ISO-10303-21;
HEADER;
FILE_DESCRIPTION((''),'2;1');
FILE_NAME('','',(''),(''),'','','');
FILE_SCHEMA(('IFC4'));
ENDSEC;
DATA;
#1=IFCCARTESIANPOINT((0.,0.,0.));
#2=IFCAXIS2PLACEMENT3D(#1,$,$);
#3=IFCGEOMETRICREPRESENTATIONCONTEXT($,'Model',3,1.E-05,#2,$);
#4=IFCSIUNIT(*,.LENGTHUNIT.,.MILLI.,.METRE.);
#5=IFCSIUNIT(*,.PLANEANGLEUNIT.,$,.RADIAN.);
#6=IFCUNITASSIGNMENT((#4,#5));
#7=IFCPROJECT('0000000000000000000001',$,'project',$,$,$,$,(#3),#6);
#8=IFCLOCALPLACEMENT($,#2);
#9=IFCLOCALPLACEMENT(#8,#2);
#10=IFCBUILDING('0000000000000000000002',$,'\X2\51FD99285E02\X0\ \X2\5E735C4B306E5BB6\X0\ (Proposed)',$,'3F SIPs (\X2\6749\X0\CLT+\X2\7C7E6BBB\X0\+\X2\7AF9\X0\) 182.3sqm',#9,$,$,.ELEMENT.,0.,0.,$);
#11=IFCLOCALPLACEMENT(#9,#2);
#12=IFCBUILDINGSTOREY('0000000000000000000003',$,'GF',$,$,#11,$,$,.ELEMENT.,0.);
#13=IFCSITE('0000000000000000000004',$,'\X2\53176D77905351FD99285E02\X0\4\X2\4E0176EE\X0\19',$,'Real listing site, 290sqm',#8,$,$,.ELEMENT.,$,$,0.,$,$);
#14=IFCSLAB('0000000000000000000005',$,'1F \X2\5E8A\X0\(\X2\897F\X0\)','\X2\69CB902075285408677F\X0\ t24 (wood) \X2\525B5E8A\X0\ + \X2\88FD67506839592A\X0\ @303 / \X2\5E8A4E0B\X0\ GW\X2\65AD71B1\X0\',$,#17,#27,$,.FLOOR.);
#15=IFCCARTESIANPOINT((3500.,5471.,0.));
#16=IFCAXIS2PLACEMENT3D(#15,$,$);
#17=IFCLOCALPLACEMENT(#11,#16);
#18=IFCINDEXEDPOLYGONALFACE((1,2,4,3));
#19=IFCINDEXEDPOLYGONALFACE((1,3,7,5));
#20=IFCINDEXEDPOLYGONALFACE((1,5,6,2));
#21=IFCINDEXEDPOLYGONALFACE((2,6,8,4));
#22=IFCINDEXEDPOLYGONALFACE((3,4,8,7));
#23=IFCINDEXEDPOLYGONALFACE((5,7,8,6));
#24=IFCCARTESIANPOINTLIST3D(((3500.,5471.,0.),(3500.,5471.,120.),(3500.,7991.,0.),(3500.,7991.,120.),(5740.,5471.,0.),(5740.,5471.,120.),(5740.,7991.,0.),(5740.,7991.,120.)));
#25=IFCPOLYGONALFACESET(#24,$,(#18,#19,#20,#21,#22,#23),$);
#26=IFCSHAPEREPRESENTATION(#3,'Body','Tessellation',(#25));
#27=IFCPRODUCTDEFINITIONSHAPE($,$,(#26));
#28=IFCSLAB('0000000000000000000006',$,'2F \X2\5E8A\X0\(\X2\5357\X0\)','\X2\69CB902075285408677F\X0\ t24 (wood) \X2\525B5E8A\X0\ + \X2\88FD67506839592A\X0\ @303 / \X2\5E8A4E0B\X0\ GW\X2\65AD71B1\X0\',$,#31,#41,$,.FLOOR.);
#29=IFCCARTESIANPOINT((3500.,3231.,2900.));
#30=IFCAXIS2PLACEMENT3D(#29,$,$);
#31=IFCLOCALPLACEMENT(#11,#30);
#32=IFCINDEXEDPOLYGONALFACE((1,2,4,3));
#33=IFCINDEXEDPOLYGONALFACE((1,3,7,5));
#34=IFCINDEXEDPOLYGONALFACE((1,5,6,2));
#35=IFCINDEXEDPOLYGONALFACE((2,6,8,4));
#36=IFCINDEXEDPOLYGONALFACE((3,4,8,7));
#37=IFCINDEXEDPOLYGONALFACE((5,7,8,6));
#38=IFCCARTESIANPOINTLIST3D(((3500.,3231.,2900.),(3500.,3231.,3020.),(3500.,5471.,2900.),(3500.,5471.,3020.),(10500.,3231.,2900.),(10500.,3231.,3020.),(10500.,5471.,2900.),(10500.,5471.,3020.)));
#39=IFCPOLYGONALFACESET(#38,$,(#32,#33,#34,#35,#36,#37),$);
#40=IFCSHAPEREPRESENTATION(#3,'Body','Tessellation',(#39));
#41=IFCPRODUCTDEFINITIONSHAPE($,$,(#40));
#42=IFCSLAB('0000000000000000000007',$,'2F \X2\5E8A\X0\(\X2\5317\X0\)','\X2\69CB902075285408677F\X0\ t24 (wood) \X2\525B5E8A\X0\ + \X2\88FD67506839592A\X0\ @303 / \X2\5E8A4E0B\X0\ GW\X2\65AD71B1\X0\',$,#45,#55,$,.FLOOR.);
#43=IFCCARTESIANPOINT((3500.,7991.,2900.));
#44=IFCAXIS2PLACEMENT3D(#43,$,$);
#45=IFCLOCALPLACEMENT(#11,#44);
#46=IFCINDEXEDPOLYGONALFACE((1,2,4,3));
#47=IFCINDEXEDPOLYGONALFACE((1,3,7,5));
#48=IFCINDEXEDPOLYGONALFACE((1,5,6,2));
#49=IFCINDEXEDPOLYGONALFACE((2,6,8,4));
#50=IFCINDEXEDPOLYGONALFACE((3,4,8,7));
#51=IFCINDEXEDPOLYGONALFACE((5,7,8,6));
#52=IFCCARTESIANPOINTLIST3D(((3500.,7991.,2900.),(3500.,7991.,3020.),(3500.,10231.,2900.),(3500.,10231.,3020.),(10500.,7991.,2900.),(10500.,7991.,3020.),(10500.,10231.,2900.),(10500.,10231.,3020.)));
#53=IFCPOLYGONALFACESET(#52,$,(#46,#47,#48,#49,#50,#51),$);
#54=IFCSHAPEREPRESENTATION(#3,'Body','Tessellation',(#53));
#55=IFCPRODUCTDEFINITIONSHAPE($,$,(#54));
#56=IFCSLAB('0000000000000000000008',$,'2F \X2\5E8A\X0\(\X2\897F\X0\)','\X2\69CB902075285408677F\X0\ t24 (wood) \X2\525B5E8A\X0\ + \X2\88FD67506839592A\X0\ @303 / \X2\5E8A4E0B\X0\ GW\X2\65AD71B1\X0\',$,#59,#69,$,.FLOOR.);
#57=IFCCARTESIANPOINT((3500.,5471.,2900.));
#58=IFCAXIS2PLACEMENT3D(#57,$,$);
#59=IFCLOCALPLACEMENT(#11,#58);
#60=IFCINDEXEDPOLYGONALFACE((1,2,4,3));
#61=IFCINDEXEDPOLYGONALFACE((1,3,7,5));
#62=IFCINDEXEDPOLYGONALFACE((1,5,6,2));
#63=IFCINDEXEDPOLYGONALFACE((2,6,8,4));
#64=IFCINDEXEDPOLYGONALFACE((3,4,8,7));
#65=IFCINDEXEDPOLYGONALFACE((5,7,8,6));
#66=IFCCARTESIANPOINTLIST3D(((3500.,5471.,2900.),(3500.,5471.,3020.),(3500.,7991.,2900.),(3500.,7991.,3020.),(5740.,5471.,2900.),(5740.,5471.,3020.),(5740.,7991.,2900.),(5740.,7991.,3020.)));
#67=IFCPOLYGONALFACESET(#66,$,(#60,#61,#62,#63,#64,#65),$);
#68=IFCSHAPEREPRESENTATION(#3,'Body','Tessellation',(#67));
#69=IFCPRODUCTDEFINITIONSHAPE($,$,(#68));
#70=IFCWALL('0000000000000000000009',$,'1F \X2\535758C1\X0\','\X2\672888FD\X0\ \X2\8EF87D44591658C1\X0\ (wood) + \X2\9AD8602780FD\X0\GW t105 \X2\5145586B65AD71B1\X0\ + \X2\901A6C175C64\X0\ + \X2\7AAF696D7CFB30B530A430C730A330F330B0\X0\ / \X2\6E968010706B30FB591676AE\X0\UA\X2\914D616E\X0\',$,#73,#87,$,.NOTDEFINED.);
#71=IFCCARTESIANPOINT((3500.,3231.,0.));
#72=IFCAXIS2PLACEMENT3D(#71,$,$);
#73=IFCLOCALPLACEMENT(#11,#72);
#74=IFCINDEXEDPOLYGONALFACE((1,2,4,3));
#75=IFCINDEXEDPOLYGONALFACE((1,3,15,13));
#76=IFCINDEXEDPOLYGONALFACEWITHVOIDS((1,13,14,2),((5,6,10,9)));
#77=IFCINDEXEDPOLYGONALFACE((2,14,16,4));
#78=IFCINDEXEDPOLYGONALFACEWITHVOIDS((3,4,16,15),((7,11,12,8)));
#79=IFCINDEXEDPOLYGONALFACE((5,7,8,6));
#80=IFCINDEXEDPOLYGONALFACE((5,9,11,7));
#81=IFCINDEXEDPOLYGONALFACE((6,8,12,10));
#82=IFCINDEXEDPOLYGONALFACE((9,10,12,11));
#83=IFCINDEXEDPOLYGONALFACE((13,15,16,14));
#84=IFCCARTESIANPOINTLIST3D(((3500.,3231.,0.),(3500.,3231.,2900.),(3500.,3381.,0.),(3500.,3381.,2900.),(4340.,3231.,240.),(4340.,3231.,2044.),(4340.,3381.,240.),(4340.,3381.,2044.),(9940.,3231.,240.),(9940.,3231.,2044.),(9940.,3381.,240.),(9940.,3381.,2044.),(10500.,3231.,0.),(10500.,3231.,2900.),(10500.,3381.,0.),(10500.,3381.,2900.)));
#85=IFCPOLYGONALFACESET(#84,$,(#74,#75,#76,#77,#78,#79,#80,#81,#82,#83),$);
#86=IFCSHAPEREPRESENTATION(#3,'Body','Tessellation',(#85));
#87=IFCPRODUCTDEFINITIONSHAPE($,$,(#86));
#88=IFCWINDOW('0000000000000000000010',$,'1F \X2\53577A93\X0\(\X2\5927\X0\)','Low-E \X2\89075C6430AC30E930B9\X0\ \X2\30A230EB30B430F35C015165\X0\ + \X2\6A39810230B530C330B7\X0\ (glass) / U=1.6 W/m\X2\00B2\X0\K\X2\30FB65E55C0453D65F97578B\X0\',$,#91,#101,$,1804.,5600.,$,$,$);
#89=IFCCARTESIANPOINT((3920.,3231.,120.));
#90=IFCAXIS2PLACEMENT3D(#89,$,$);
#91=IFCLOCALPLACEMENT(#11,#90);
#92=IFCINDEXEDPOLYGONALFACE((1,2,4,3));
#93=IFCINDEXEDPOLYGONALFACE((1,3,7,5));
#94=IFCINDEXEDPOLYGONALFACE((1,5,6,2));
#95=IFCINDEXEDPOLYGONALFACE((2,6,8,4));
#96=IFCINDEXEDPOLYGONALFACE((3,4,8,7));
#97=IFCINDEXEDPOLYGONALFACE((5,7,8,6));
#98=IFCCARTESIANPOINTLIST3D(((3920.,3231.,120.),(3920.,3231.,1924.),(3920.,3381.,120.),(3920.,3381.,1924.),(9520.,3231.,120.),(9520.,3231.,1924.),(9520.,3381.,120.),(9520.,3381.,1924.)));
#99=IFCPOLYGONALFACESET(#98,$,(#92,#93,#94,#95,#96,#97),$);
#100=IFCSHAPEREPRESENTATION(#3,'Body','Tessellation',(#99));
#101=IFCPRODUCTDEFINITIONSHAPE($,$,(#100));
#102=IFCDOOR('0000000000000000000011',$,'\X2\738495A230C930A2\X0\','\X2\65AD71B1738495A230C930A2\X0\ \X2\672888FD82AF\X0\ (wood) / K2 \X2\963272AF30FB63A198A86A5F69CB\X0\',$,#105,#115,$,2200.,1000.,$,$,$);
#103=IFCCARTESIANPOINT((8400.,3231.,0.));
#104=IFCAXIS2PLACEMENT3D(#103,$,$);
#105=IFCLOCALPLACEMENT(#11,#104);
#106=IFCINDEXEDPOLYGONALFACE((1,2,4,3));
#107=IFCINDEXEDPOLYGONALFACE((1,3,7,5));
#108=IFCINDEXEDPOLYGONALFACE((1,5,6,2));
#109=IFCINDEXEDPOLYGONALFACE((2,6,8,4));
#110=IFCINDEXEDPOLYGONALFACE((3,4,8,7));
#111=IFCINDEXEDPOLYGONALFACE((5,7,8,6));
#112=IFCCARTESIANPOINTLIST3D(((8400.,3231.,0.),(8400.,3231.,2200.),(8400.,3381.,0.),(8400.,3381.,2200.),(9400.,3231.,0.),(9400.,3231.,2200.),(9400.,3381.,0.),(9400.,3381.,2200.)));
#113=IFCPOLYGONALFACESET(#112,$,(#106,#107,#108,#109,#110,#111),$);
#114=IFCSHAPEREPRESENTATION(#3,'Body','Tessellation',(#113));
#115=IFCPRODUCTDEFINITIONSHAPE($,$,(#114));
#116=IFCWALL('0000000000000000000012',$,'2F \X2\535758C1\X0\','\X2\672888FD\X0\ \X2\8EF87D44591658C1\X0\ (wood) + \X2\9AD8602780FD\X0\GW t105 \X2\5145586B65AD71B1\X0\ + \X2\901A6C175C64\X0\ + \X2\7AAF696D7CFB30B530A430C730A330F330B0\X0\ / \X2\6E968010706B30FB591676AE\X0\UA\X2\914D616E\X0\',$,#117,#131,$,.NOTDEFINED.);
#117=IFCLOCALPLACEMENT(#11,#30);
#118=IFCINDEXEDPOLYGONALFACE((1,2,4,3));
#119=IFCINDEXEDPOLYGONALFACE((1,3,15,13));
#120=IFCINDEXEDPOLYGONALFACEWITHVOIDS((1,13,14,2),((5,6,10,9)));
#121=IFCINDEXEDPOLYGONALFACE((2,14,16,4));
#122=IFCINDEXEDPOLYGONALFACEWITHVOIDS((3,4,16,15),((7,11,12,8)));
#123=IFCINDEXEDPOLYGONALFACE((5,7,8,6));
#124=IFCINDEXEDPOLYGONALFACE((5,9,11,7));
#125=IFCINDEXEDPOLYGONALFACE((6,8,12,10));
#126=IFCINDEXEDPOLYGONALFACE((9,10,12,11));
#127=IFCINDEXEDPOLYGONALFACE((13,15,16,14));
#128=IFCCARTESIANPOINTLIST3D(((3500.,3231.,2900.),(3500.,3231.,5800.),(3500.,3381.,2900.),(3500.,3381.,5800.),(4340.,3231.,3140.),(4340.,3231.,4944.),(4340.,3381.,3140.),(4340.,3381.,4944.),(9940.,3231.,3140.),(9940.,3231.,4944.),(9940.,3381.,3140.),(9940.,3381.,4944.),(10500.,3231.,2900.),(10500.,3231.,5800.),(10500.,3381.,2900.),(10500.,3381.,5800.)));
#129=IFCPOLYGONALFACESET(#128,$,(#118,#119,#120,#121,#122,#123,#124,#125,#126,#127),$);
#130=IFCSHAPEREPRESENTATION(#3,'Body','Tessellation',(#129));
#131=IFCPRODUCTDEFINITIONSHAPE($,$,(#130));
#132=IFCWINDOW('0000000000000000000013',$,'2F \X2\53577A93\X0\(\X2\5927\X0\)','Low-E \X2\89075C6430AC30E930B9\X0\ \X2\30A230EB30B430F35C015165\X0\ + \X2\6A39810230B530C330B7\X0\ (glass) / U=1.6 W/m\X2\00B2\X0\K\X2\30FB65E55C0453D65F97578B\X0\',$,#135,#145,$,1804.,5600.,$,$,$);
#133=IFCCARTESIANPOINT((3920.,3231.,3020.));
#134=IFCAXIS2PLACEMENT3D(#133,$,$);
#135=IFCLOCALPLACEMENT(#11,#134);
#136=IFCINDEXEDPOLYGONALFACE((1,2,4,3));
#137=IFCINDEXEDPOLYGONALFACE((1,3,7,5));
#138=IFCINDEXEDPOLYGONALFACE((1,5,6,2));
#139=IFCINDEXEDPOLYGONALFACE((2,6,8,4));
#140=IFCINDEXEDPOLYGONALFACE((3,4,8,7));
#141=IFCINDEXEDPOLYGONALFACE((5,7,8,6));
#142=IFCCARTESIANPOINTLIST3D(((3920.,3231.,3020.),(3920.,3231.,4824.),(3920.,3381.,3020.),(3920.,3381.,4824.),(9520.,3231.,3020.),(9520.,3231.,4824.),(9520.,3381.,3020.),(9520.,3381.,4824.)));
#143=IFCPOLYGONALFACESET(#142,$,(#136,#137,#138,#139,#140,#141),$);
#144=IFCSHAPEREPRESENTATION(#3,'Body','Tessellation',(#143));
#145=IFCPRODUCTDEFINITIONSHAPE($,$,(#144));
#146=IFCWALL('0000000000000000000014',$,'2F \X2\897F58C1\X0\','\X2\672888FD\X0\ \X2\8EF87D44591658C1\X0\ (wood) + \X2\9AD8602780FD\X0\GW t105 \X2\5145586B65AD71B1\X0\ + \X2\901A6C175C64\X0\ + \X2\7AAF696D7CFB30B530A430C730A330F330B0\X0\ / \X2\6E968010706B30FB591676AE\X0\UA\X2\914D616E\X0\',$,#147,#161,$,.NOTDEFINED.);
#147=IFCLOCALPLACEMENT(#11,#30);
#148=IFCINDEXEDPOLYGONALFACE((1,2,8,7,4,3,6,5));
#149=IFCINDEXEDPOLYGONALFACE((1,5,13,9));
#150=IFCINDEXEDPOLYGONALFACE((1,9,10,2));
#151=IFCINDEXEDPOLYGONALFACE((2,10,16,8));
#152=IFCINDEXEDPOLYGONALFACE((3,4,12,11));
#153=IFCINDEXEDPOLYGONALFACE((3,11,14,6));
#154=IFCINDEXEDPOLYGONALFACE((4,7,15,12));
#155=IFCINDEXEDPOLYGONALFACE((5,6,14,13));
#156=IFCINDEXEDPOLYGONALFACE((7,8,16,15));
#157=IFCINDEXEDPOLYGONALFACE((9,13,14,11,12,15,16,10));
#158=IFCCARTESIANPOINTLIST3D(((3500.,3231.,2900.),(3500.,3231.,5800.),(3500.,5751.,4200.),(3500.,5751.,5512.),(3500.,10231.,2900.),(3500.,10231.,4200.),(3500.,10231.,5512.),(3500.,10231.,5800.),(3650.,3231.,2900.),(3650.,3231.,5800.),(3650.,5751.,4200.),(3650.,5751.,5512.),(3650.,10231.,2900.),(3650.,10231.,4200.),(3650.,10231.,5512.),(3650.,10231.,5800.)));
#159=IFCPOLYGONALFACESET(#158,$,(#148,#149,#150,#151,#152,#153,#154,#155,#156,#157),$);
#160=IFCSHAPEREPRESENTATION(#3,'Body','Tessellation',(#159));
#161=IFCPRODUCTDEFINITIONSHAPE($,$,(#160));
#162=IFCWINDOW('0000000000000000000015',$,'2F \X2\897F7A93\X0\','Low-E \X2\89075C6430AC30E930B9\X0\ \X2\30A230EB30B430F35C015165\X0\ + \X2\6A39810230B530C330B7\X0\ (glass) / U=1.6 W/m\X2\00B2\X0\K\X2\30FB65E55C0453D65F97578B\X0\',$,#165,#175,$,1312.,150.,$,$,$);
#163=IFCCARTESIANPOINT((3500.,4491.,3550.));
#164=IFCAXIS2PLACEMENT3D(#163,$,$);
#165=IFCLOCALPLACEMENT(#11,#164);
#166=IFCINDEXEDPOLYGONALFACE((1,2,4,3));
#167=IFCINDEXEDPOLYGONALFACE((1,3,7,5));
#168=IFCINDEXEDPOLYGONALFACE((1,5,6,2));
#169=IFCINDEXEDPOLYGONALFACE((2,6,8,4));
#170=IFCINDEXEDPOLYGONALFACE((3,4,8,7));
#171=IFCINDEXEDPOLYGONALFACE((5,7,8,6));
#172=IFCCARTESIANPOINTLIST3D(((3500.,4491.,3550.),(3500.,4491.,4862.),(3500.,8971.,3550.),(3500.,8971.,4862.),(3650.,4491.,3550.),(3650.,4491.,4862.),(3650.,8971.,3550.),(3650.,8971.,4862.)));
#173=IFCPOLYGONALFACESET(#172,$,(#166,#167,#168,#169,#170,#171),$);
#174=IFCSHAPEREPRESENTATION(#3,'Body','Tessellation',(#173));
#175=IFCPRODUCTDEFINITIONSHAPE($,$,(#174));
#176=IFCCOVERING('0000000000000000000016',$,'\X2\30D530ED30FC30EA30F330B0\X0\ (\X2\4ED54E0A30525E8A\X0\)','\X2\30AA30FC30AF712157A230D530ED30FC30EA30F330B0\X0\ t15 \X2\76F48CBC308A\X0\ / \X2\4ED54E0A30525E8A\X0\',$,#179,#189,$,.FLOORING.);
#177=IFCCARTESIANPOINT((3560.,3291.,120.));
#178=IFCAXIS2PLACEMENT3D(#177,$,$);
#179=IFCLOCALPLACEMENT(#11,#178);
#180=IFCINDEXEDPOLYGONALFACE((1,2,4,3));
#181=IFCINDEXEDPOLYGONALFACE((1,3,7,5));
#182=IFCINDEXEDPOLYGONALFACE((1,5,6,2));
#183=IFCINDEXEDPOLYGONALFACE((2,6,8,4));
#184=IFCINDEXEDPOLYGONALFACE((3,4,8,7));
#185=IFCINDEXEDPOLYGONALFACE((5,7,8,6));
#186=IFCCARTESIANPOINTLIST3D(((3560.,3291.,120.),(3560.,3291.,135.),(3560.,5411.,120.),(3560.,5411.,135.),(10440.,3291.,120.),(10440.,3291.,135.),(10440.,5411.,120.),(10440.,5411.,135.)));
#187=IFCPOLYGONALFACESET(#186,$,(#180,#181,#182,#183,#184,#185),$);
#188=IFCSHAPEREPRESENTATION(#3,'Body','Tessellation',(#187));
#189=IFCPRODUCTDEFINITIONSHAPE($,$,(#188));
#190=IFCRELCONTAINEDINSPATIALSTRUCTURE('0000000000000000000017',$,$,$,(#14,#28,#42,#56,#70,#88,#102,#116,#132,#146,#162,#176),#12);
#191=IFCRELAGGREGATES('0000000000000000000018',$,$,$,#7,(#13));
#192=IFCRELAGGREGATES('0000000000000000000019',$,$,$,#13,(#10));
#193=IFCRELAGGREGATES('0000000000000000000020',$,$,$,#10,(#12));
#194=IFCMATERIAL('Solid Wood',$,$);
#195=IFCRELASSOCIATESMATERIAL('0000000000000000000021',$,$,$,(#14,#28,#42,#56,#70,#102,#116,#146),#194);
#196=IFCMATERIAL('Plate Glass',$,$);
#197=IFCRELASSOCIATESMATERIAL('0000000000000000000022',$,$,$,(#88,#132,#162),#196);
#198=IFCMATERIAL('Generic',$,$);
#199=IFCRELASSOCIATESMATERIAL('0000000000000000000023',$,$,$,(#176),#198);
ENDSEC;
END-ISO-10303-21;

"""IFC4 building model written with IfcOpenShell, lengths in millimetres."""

from ifc_helpers import new_model, si_unit, frame, frame_2d, origin, place, context, project, spatial, rectangle, extrude, material, element, fill, save


model = new_model("IFC4")

# Units and contexts
model_context = context("Model", 3, precision=1e-05, world=origin())
ifc_project = project(units=[si_unit("LENGTHUNIT", "METRE", prefix="MILLI"), si_unit("PLANEANGLEUNIT", "RADIAN")], contexts=[model_context])

# Site, building, storey
site_placement = place(None, origin())
site = spatial("IfcSite", under=ifc_project, at=site_placement, Name="北海道函館市4丁目19", ObjectType="Real listing site, 290sqm", CompositionType="ELEMENT", RefElevation=0.0)
building_placement = place(site_placement, origin())
building = spatial("IfcBuilding", under=site, at=building_placement, Name="函館市 平屋の家 (Proposed)", ObjectType="3F SIPs (杉CLT+籾殻+竹) 182.3sqm", CompositionType="ELEMENT", ElevationOfRefHeight=0.0, ElevationOfTerrain=0.0)
storey_placement = place(building_placement, origin())
storey = spatial("IfcBuildingStorey", under=building, at=storey_placement, Name="GF", CompositionType="ELEMENT", Elevation=0.0)

# Slabs
ifc_material_1 = material(Name="Solid Wood")
slab_1_placement = place(storey_placement, frame((3500.0, 5471.0, 0.0)))
element("IfcSlab", 1, at=slab_1_placement, inside=storey, material=ifc_material_1, Name="1F 床(西)", Description="構造用合板 t24 (wood) 剛床 + 製材根太 @303 / 床下 GW断熱", PredefinedType="FLOOR", context=model_context, shape_type="SweptSolid", body=[
    extrude(rectangle(XDim=2240.0, YDim=2520.0, at=frame_2d((1120.0, 1260.0))), frame((3500.0, 5471.0, 0.0)), (0.0, 0.0, 1.0), 120.0),
])
slab_2_placement = place(storey_placement, frame((3500.0, 3231.0, 2900.0)))
element("IfcSlab", 2, at=slab_2_placement, inside=storey, material=ifc_material_1, Name="2F 床(南)", Description="構造用合板 t24 (wood) 剛床 + 製材根太 @303 / 床下 GW断熱", PredefinedType="FLOOR", context=model_context, shape_type="SweptSolid", body=[
    extrude(rectangle(XDim=7000.0, YDim=2240.0, at=frame_2d((3500.0, 1120.0))), frame((3500.0, 3231.0, 2900.0)), (0.0, 0.0, 1.0), 120.0),
])
slab_3_placement = place(storey_placement, frame((3500.0, 7991.0, 2900.0)))
element("IfcSlab", 3, at=slab_3_placement, inside=storey, material=ifc_material_1, Name="2F 床(北)", Description="構造用合板 t24 (wood) 剛床 + 製材根太 @303 / 床下 GW断熱", PredefinedType="FLOOR", context=model_context, shape_type="SweptSolid", body=[
    extrude(rectangle(XDim=7000.0, YDim=2240.0, at=frame_2d((3500.0, 1120.0))), frame((3500.0, 7991.0, 2900.0)), (0.0, 0.0, 1.0), 120.0),
])
slab_4_placement = place(storey_placement, frame((3500.0, 5471.0, 2900.0)))
element("IfcSlab", 4, at=slab_4_placement, inside=storey, material=ifc_material_1, Name="2F 床(西)", Description="構造用合板 t24 (wood) 剛床 + 製材根太 @303 / 床下 GW断熱", PredefinedType="FLOOR", context=model_context, shape_type="SweptSolid", body=[
    extrude(rectangle(XDim=2240.0, YDim=2520.0, at=frame_2d((1120.0, 1260.0))), frame((3500.0, 5471.0, 2900.0)), (0.0, 0.0, 1.0), 120.0),
])

# Wall, openings, window, door
wall_1_placement = place(storey_placement, frame((3500.0, 3231.0, 0.0)))
wall_1 = element("IfcWall", 5, at=wall_1_placement, inside=storey, material=ifc_material_1, Name="1F 南壁", Description="木製 軸組外壁 (wood) + 高性能GW t105 充填断熱 + 通気層 + 窯業系サイディング / 準耐火・外皮UA配慮", PredefinedType="NOTDEFINED", context=model_context, shape_type="SweptSolid", body=[
    extrude(rectangle(XDim=7000.0, YDim=150.0, at=frame_2d((3500.0, 75.0))), frame((3500.0, 3231.0, 0.0)), (0.0, 0.0, 1.0), 2900.0),
])
opening_1_placement = place(storey_placement, frame((3920.0, 3231.0, 120.0)))
opening_1 = element("IfcOpeningElement", 6, at=opening_1_placement, cuts=wall_1, PredefinedType="NOTDEFINED", context=model_context, shape_type="SweptSolid", body=[
    extrude(rectangle(XDim=5600.0, YDim=150.0, at=frame_2d((2800.0, 75.0))), frame((3920.0, 3231.0, 120.0)), (0.0, 0.0, 1.0), 1804.0),
])
opening_2_placement = place(storey_placement, frame((8400.0, 3231.0, 0.0)))
opening_2 = element("IfcOpeningElement", 7, at=opening_2_placement, cuts=wall_1, PredefinedType="NOTDEFINED", context=model_context, shape_type="SweptSolid", body=[
    extrude(rectangle(XDim=1000.0, YDim=150.0, at=frame_2d((500.0, 75.0))), frame((8400.0, 3231.0, 0.0)), (0.0, 0.0, 1.0), 2200.0),
])
ifc_material_2 = material(Name="Plate Glass")
window_1_placement = place(storey_placement, frame((3920.0, 3231.0, 120.0)))
window_1 = element("IfcWindow", 8, at=window_1_placement, inside=storey, material=ifc_material_2, Name="1F 南窓(大)", Description="Low-E 複層ガラス アルゴン封入 + 樹脂サッシ (glass) / U=1.6 W/m²K・日射取得型", OverallHeight=1804.0, OverallWidth=5600.0, context=model_context, shape_type="SweptSolid", body=[
    extrude(rectangle(XDim=5600.0, YDim=150.0, at=frame_2d((2800.0, 75.0))), frame((3920.0, 3231.0, 120.0)), (0.0, 0.0, 1.0), 1804.0),
])
fill(opening_1, window_1)
door_placement = place(storey_placement, frame((8400.0, 3231.0, 0.0)))
door = element("IfcDoor", 9, at=door_placement, inside=storey, material=ifc_material_1, Name="玄関ドア", Description="断熱玄関ドア 木製芯 (wood) / K2 防犯・採風機構", OverallHeight=2200.0, OverallWidth=1000.0, context=model_context, shape_type="SweptSolid", body=[
    extrude(rectangle(XDim=1000.0, YDim=150.0, at=frame_2d((500.0, 75.0))), frame((8400.0, 3231.0, 0.0)), (0.0, 0.0, 1.0), 2200.0),
])
fill(opening_2, door)

# Wall, opening, window
wall_2_placement = place(storey_placement, frame((3500.0, 3231.0, 2900.0)))
wall_2 = element("IfcWall", 10, at=wall_2_placement, inside=storey, material=ifc_material_1, Name="2F 南壁", Description="木製 軸組外壁 (wood) + 高性能GW t105 充填断熱 + 通気層 + 窯業系サイディング / 準耐火・外皮UA配慮", PredefinedType="NOTDEFINED", context=model_context, shape_type="SweptSolid", body=[
    extrude(rectangle(XDim=7000.0, YDim=150.0, at=frame_2d((3500.0, 75.0))), frame((3500.0, 3231.0, 2900.0)), (0.0, 0.0, 1.0), 2900.0),
])
opening_3_placement = place(storey_placement, frame((3920.0, 3231.0, 3020.0)))
opening_3 = element("IfcOpeningElement", 11, at=opening_3_placement, cuts=wall_2, PredefinedType="NOTDEFINED", context=model_context, shape_type="SweptSolid", body=[
    extrude(rectangle(XDim=5600.0, YDim=150.0, at=frame_2d((2800.0, 75.0))), frame((3920.0, 3231.0, 3020.0)), (0.0, 0.0, 1.0), 1804.0),
])
window_2_placement = place(storey_placement, frame((3920.0, 3231.0, 3020.0)))
window_2 = element("IfcWindow", 12, at=window_2_placement, inside=storey, material=ifc_material_2, Name="2F 南窓(大)", Description="Low-E 複層ガラス アルゴン封入 + 樹脂サッシ (glass) / U=1.6 W/m²K・日射取得型", OverallHeight=1804.0, OverallWidth=5600.0, context=model_context, shape_type="SweptSolid", body=[
    extrude(rectangle(XDim=5600.0, YDim=150.0, at=frame_2d((2800.0, 75.0))), frame((3920.0, 3231.0, 3020.0)), (0.0, 0.0, 1.0), 1804.0),
])
fill(opening_3, window_2)

# Wall, opening, window
wall_3_placement = place(storey_placement, frame((3500.0, 3231.0, 2900.0)))
wall_3 = element("IfcWall", 13, at=wall_3_placement, inside=storey, material=ifc_material_1, Name="2F 西壁", Description="木製 軸組外壁 (wood) + 高性能GW t105 充填断熱 + 通気層 + 窯業系サイディング / 準耐火・外皮UA配慮", PredefinedType="NOTDEFINED", context=model_context, shape_type="SweptSolid", body=[
    extrude(rectangle(XDim=150.0, YDim=7000.0, at=frame_2d((75.0, 3500.0))), frame((3500.0, 3231.0, 2900.0)), (0.0, 0.0, 1.0), 2900.0),
])
opening_4_placement = place(storey_placement, frame((3500.0, 4491.0, 3550.0)))
opening_4 = element("IfcOpeningElement", 14, at=opening_4_placement, cuts=wall_3, PredefinedType="NOTDEFINED", context=model_context, shape_type="SweptSolid", body=[
    extrude(rectangle(XDim=150.0, YDim=4480.0, at=frame_2d((75.0, 2240.0))), frame((3500.0, 4491.0, 3550.0)), (0.0, 0.0, 1.0), 1312.0),
])
window_3_placement = place(storey_placement, frame((3500.0, 4491.0, 3550.0)))
window_3 = element("IfcWindow", 15, at=window_3_placement, inside=storey, material=ifc_material_2, Name="2F 西窓", Description="Low-E 複層ガラス アルゴン封入 + 樹脂サッシ (glass) / U=1.6 W/m²K・日射取得型", OverallHeight=1312.0, OverallWidth=150.0, context=model_context, shape_type="SweptSolid", body=[
    extrude(rectangle(XDim=150.0, YDim=4480.0, at=frame_2d((75.0, 2240.0))), frame((3500.0, 4491.0, 3550.0)), (0.0, 0.0, 1.0), 1312.0),
])
fill(opening_4, window_3)

# Covering
ifc_material_3 = material(Name="Generic")
covering_1_placement = place(storey_placement, frame((3560.0, 3291.0, 120.0)))
element("IfcCovering", 16, at=covering_1_placement, inside=storey, material=ifc_material_3, Name="フローリング (仕上げ床)", Description="オーク無垢フローリング t15 直貼り / 仕上げ床", PredefinedType="FLOORING", context=model_context, shape_type="SweptSolid", body=[
    extrude(rectangle(XDim=6880.0, YDim=2120.0, at=frame_2d((3440.0, 1060.0))), frame((3560.0, 3291.0, 120.0)), (0.0, 0.0, 1.0), 15.0),
])

save(model, "model.ifc")
